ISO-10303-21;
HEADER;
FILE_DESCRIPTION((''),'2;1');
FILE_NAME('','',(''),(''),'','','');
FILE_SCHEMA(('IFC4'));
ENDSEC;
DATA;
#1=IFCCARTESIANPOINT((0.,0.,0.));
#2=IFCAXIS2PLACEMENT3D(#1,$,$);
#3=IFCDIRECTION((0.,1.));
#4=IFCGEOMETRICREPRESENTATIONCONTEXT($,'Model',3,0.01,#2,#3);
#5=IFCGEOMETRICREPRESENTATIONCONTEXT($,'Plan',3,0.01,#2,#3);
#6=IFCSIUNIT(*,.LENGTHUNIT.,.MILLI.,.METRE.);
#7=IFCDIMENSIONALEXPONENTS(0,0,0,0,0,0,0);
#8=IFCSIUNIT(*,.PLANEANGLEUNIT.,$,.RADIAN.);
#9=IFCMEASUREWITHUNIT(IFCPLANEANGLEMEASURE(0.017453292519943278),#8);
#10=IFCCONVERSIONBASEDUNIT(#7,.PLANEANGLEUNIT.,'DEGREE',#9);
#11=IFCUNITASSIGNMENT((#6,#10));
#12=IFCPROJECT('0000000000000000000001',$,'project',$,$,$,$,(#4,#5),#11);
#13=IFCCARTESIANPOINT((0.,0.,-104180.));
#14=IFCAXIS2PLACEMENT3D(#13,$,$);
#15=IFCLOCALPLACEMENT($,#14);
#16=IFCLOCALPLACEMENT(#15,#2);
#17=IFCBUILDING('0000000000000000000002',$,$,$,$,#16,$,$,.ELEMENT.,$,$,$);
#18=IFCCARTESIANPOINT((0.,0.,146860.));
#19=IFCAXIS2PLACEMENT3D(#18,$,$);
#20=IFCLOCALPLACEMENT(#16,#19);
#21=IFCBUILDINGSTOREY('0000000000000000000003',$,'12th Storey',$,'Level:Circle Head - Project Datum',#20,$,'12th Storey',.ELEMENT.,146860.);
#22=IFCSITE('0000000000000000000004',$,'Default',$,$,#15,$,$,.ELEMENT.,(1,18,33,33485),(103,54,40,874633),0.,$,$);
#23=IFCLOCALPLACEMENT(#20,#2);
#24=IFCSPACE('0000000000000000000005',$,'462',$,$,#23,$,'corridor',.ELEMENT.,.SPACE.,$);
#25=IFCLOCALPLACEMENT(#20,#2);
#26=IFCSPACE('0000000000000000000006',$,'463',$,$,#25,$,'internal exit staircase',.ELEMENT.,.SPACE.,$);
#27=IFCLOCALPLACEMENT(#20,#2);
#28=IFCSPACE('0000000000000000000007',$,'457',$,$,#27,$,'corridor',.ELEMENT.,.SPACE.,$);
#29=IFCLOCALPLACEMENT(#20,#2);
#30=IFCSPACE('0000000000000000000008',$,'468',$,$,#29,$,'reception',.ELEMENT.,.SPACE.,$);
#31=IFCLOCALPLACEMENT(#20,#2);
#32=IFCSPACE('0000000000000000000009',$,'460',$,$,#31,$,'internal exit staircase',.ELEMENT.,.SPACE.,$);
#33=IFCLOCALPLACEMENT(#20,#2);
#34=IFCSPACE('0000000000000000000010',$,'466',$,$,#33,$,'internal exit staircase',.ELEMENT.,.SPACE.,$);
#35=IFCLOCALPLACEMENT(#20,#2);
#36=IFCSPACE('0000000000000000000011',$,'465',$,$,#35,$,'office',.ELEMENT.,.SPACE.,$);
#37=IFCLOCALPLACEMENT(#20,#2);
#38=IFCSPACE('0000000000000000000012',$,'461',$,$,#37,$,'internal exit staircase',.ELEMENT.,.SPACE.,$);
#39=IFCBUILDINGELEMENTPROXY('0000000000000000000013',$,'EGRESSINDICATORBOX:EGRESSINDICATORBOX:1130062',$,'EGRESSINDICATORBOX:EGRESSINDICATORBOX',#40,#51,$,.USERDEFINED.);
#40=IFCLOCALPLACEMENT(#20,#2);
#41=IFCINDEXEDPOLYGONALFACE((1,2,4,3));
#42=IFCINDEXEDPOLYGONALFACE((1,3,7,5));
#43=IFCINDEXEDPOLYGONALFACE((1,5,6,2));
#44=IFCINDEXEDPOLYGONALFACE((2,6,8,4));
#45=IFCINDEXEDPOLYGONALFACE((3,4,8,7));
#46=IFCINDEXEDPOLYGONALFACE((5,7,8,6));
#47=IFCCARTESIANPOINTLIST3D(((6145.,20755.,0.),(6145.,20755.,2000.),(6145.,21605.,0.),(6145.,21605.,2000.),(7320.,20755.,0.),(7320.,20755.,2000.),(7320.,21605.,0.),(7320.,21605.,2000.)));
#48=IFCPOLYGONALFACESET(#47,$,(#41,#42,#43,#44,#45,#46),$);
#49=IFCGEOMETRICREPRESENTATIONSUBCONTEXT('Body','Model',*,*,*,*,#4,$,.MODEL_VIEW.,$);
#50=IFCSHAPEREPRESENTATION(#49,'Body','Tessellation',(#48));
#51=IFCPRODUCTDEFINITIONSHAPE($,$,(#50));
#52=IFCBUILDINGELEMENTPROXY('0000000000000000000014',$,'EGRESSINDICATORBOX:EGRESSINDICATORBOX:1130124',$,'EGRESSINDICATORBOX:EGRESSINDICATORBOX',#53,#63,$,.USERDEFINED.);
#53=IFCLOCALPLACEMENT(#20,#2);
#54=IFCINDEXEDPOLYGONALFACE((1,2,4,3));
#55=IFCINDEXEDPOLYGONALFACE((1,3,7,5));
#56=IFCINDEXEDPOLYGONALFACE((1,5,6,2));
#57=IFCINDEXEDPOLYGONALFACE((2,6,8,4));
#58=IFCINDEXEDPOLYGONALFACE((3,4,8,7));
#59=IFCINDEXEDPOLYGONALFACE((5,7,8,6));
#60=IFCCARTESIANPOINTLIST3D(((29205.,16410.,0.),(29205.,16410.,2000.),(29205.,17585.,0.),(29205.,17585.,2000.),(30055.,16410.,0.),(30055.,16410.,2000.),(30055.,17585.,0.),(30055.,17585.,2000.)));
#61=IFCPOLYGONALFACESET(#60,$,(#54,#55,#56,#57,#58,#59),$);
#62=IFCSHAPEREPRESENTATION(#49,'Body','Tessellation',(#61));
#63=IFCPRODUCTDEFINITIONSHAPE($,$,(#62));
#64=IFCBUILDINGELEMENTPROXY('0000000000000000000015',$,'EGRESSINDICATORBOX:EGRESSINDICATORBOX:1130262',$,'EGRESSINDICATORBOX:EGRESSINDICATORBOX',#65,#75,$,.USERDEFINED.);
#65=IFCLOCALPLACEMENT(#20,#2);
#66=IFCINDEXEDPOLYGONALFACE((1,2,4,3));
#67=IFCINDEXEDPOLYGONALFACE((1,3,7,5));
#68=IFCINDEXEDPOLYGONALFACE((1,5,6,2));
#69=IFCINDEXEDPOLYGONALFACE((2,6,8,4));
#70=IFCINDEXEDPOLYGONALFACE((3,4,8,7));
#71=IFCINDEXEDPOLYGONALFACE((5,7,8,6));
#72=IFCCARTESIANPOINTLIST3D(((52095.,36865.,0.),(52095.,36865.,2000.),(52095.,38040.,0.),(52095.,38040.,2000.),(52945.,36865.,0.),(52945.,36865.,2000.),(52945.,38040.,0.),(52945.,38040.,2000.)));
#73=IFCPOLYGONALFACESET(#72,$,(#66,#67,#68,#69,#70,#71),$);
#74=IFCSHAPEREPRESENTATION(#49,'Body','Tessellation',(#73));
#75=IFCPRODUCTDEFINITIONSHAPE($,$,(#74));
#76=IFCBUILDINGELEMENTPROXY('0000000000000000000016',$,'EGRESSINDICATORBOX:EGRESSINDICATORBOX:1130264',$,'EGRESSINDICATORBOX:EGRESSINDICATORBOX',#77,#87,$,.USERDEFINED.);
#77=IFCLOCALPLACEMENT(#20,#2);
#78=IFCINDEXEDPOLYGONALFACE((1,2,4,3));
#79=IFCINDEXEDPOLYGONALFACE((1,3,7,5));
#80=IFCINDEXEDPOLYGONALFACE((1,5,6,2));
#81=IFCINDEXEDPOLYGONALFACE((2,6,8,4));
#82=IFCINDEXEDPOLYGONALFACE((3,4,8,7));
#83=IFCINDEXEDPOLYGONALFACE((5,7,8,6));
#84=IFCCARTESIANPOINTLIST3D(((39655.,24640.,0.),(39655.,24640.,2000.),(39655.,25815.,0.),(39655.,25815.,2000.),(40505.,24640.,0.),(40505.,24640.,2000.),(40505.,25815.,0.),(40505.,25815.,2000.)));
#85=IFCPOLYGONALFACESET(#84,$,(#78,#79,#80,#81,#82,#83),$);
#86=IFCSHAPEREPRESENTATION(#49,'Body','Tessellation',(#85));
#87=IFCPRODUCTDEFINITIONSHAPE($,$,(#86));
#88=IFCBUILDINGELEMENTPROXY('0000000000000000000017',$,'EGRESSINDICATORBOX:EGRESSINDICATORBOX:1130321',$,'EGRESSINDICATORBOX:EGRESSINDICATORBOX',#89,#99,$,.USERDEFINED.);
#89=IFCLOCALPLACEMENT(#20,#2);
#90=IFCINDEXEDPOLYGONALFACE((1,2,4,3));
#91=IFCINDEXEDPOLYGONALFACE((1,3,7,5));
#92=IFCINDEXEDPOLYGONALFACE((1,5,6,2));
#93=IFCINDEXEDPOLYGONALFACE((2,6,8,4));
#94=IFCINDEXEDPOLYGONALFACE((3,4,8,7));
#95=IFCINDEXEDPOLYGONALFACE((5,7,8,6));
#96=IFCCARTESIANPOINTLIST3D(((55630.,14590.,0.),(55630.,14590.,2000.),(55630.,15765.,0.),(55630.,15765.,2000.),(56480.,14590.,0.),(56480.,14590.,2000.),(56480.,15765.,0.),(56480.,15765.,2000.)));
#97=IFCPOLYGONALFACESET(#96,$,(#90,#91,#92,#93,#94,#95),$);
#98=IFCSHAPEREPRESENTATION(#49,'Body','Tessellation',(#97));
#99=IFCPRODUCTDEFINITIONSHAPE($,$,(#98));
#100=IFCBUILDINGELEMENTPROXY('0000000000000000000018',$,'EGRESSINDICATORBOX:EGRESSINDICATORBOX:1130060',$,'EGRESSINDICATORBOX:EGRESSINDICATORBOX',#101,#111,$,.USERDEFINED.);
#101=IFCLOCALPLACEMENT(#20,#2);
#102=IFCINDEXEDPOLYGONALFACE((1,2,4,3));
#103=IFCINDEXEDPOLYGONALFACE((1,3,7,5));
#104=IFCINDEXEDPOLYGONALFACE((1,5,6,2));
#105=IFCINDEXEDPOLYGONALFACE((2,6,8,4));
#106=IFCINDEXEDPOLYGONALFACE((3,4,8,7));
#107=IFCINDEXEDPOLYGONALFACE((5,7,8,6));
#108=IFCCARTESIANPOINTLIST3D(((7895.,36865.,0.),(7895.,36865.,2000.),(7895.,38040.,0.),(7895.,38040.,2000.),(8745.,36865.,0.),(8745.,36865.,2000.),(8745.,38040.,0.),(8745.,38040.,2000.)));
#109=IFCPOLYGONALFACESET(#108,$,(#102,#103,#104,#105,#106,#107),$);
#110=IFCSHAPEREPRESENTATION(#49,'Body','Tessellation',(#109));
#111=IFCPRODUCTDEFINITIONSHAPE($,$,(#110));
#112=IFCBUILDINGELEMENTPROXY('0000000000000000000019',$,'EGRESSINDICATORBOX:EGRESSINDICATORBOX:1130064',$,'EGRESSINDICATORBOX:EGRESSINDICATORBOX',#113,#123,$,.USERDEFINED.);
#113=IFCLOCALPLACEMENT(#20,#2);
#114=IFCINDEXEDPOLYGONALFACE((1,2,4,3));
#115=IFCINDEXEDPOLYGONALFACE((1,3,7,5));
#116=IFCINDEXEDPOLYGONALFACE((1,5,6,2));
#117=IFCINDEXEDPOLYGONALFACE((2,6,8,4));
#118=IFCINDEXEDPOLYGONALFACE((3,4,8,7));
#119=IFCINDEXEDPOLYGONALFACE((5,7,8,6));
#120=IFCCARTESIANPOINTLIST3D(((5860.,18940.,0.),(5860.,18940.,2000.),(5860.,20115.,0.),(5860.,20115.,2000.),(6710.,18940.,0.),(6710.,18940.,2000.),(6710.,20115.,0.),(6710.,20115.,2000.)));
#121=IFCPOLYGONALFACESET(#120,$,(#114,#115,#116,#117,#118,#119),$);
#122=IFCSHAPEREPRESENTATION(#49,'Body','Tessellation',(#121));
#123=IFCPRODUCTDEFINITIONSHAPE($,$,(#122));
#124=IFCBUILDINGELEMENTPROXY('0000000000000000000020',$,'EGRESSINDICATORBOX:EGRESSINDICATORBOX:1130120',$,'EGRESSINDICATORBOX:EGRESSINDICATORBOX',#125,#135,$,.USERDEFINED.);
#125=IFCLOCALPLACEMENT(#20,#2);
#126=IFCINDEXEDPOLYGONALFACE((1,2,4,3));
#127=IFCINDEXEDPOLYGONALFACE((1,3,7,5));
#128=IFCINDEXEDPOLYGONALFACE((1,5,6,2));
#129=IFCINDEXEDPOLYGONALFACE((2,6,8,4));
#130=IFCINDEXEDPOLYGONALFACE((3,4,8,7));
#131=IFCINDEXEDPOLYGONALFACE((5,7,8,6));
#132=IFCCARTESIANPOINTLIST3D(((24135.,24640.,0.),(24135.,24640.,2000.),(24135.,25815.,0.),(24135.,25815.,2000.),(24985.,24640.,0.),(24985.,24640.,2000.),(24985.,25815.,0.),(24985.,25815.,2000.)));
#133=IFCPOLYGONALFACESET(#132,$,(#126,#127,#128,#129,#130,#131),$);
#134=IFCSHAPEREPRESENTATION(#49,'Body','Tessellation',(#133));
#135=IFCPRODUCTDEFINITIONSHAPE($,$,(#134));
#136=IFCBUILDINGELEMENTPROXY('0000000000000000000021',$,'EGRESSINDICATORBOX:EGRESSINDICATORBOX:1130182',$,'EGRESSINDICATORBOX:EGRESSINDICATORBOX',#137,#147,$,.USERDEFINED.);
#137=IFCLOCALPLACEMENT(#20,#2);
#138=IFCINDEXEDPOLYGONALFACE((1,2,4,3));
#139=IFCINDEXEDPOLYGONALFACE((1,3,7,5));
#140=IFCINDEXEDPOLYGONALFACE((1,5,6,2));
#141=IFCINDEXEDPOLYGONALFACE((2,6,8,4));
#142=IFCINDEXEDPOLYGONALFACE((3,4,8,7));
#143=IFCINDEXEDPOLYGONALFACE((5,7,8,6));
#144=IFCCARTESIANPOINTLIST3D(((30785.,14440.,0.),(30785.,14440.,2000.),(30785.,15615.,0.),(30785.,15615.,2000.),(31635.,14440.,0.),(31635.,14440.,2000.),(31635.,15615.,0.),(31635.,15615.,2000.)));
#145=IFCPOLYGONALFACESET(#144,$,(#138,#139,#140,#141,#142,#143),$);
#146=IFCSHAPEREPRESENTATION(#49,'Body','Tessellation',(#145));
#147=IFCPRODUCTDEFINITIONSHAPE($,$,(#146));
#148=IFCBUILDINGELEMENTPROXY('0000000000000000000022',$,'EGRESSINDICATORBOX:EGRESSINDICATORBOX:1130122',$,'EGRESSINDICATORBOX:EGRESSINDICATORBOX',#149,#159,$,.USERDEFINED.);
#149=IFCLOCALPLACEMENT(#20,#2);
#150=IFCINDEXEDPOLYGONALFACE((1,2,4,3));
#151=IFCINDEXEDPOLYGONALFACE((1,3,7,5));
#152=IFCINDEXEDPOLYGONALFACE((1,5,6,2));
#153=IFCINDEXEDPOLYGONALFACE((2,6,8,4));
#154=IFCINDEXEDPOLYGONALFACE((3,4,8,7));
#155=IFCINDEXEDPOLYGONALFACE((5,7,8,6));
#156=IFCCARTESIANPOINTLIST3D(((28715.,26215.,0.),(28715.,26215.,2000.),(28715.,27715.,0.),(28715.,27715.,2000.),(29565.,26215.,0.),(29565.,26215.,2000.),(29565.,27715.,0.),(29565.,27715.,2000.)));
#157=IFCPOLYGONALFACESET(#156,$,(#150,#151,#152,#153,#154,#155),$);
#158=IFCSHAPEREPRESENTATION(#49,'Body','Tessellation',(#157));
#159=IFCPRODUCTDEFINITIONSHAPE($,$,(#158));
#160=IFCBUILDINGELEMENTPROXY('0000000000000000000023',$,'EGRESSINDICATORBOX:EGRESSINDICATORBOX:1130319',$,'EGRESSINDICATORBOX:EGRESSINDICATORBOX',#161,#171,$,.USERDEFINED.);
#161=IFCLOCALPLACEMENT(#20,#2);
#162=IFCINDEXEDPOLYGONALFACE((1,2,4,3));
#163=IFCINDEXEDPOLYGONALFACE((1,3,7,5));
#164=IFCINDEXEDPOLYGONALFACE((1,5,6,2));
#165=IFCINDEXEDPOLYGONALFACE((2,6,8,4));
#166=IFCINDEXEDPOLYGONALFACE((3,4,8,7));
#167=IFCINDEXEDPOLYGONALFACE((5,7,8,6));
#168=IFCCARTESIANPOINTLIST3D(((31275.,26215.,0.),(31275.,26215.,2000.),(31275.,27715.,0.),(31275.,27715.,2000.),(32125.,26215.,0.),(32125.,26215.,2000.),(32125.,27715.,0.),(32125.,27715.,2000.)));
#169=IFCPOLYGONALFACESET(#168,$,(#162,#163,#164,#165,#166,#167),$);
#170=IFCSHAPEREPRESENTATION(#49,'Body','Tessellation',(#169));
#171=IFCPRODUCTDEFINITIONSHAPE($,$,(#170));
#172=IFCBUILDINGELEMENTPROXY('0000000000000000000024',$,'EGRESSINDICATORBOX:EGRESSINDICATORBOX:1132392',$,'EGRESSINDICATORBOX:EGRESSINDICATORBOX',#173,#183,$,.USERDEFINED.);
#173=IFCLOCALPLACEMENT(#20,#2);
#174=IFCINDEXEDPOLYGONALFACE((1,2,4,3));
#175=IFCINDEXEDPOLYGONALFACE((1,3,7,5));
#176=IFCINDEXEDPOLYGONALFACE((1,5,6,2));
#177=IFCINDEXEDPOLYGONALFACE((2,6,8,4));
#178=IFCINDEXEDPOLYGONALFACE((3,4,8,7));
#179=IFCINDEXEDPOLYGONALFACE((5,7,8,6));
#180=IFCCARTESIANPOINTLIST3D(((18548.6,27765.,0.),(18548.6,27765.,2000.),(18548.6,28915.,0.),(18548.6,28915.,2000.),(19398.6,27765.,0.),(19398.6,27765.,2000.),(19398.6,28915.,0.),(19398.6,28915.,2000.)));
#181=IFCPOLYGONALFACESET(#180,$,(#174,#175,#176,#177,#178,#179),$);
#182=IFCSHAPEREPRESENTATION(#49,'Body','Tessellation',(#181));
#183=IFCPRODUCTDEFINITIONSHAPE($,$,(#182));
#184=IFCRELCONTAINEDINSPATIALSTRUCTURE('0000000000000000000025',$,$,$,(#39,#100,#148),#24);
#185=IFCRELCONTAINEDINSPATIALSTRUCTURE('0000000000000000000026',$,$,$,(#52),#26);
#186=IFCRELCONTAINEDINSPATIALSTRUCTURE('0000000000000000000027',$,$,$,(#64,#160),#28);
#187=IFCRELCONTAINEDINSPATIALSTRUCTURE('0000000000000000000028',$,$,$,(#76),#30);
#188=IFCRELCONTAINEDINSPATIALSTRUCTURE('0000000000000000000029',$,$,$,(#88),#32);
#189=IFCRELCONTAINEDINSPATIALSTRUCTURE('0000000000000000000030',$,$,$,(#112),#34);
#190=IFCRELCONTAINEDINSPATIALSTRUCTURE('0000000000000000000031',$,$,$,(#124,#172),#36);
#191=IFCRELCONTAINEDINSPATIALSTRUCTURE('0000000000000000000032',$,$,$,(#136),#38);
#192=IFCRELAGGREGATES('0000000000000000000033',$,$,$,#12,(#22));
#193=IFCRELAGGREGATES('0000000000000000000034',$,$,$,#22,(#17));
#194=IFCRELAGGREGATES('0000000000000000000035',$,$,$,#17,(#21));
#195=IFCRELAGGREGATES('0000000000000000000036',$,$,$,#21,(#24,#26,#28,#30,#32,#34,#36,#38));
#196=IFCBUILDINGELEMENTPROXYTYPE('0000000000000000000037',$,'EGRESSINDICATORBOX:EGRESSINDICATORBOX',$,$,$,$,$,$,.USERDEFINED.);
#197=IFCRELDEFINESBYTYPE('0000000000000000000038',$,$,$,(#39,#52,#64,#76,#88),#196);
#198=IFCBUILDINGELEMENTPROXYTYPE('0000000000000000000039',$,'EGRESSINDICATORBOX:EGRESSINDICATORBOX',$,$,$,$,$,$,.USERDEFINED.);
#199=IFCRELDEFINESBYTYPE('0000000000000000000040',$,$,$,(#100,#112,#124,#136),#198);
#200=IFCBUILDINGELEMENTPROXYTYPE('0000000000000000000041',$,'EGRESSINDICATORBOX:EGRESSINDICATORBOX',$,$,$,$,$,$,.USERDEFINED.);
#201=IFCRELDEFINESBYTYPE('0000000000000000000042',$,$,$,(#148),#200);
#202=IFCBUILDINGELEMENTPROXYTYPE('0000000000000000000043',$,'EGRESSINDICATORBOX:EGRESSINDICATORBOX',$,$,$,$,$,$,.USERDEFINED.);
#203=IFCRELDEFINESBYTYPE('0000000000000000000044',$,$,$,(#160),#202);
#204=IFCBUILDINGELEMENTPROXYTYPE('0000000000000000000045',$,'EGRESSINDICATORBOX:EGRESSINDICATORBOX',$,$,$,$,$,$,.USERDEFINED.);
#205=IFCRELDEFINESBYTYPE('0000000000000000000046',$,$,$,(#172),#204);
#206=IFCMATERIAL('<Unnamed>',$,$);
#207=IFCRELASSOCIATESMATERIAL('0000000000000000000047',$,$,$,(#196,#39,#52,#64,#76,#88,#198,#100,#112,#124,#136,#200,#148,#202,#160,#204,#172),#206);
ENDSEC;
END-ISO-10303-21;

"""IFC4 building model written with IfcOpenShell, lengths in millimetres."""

from ifc_helpers import new_model, entity, si_unit, converted_unit, direction, frame, origin, place, context, subcontext, project, spatial, indexed_curve, outline, extrude, source, transform, mapped, material, type_object, type_shapes, element, save


model = new_model("IFC4")

# Units and contexts
model_context = context("Model", 3, precision=0.01, world=origin(), true_north=direction((0.0, 1.0)))
plan_context = context("Plan", 3, precision=0.01, world=origin(), true_north=direction((0.0, 1.0)))
body_context = subcontext(model_context, "Body", "Model", "MODEL_VIEW")
ifc_project = project(units=[si_unit("LENGTHUNIT", "METRE", prefix="MILLI"), converted_unit("PLANEANGLEUNIT", "DEGREE", entity("IfcPlaneAngleMeasure", 0.017453292519943278), si_unit("PLANEANGLEUNIT", "RADIAN"), dimensions=[0, 0, 0, 0, 0, 0, 0])], contexts=[model_context, plan_context])

# Site, building, storey
site_placement = place(None, frame((0.0, 0.0, -104180.0)))
site = spatial("IfcSite", under=ifc_project, at=site_placement, Name="Default", CompositionType="ELEMENT", RefLatitude=(1, 18, 33, 33485), RefLongitude=(103, 54, 40, 874633), RefElevation=0.0)
building_placement = place(site_placement, origin())
building = spatial("IfcBuilding", under=site, at=building_placement, CompositionType="ELEMENT")
storey_placement = place(building_placement, frame((0.0, 0.0, 146860.0)))
storey = spatial("IfcBuildingStorey", under=building, at=storey_placement, Name="12th Storey", ObjectType="Level:Circle Head - Project Datum", LongName="12th Storey", CompositionType="ELEMENT", Elevation=146860.0)

# Shared definitions
space_1_placement = place(storey_placement, origin())
space_1 = spatial("IfcSpace", under=storey, at=space_1_placement, Name="462", LongName="corridor", CompositionType="ELEMENT", PredefinedType="SPACE")

# Building element proxy
ifc_material_1 = material(Name="<Unnamed>")
building_element_proxy_type_1 = type_object("IfcBuildingElementProxyType", Name="EGRESSINDICATORBOX:EGRESSINDICATORBOX", PredefinedType="USERDEFINED", material=ifc_material_1)
shared_shape_1 = source(origin(), body_context, "Body", "SweptSolid", [
    extrude(outline(indexed_curve([(-587.5, -425.0), (587.5, -425.0), (587.5, 425.0), (-587.5, 425.0), (-587.5, -425.0)], self_intersect=False)), frame((0.0, 0.0, 0.0), z_axis=(0.0, 0.0, 1.0), x_axis=(0.0, 1.0, 0.0)), (0.0, 0.0, 1.0), 2000.0),
])
type_shapes(building_element_proxy_type_1, [shared_shape_1])
proxy_1_placement = place(space_1_placement, frame((6732.5, 21180.0, 0.0), z_axis=(0.0, 0.0, 1.0), x_axis=(0.0, -1.0, 0.0)))
element("IfcBuildingElementProxy", 1, at=proxy_1_placement, inside=space_1, type_object=building_element_proxy_type_1, material=ifc_material_1, Name="EGRESSINDICATORBOX:EGRESSINDICATORBOX:1130062", ObjectType="EGRESSINDICATORBOX:EGRESSINDICATORBOX", PredefinedType="USERDEFINED", context=body_context, shape_type="MappedRepresentation", body=[
    mapped(shared_shape_1, transform((0.0, 0.0, 0.0), scale=1.0)),
])

# Shared definitions
space_2_placement = place(storey_placement, origin())
space_2 = spatial("IfcSpace", under=storey, at=space_2_placement, Name="463", LongName="internal exit staircase", CompositionType="ELEMENT", PredefinedType="SPACE")

# Building element proxy
proxy_2_placement = place(space_2_placement, frame((29630.0, 16997.5, 0.0)))
element("IfcBuildingElementProxy", 2, at=proxy_2_placement, inside=space_2, type_object=building_element_proxy_type_1, material=ifc_material_1, Name="EGRESSINDICATORBOX:EGRESSINDICATORBOX:1130124", ObjectType="EGRESSINDICATORBOX:EGRESSINDICATORBOX", PredefinedType="USERDEFINED", context=body_context, shape_type="MappedRepresentation", body=[
    mapped(shared_shape_1, transform((0.0, 0.0, 0.0), scale=1.0)),
])

# Shared definitions
space_3_placement = place(storey_placement, origin())
space_3 = spatial("IfcSpace", under=storey, at=space_3_placement, Name="457", LongName="corridor", CompositionType="ELEMENT", PredefinedType="SPACE")

# Building element proxy
proxy_3_placement = place(space_3_placement, frame((52520.0, 37452.5, 0.0), z_axis=(0.0, 0.0, 1.0), x_axis=(-1.0, 0.0, 0.0)))
element("IfcBuildingElementProxy", 3, at=proxy_3_placement, inside=space_3, type_object=building_element_proxy_type_1, material=ifc_material_1, Name="EGRESSINDICATORBOX:EGRESSINDICATORBOX:1130262", ObjectType="EGRESSINDICATORBOX:EGRESSINDICATORBOX", PredefinedType="USERDEFINED", context=body_context, shape_type="MappedRepresentation", body=[
    mapped(shared_shape_1, transform((0.0, 0.0, 0.0), scale=1.0)),
])

# Shared definitions
space_4_placement = place(storey_placement, origin())
space_4 = spatial("IfcSpace", under=storey, at=space_4_placement, Name="468", LongName="reception", CompositionType="ELEMENT", PredefinedType="SPACE")

# Building element proxy
proxy_4_placement = place(space_4_placement, frame((40080.0, 25227.5, 0.0), z_axis=(0.0, 0.0, 1.0), x_axis=(-1.0, 0.0, 0.0)))
element("IfcBuildingElementProxy", 4, at=proxy_4_placement, inside=space_4, type_object=building_element_proxy_type_1, material=ifc_material_1, Name="EGRESSINDICATORBOX:EGRESSINDICATORBOX:1130264", ObjectType="EGRESSINDICATORBOX:EGRESSINDICATORBOX", PredefinedType="USERDEFINED", context=body_context, shape_type="MappedRepresentation", body=[
    mapped(shared_shape_1, transform((0.0, 0.0, 0.0), scale=1.0)),
])

# Shared definitions
space_5_placement = place(storey_placement, origin())
space_5 = spatial("IfcSpace", under=storey, at=space_5_placement, Name="460", LongName="internal exit staircase", CompositionType="ELEMENT", PredefinedType="SPACE")

# Building element proxies
proxy_5_placement = place(space_5_placement, frame((56055.0, 15177.5, 0.0)))
element("IfcBuildingElementProxy", 5, at=proxy_5_placement, inside=space_5, type_object=building_element_proxy_type_1, material=ifc_material_1, Name="EGRESSINDICATORBOX:EGRESSINDICATORBOX:1130321", ObjectType="EGRESSINDICATORBOX:EGRESSINDICATORBOX", PredefinedType="USERDEFINED", context=body_context, shape_type="MappedRepresentation", body=[
    mapped(shared_shape_1, transform((0.0, 0.0, 0.0), scale=1.0)),
])
building_element_proxy_type_2 = type_object("IfcBuildingElementProxyType", Name="EGRESSINDICATORBOX:EGRESSINDICATORBOX", PredefinedType="USERDEFINED", material=ifc_material_1)
shared_shape_2 = source(origin(), body_context, "Body", "SweptSolid", [
    extrude(outline(indexed_curve([(-425.0, -587.5), (425.0, -587.5), (425.0, 587.5), (-425.0, 587.5), (-425.0, -587.5)], self_intersect=False)), frame((0.0, 0.0, 0.0), z_axis=(0.0, 0.0, 1.0), x_axis=(-1.0, 0.0, 0.0)), (0.0, 0.0, 1.0), 2000.0),
])
type_shapes(building_element_proxy_type_2, [shared_shape_2])
proxy_6_placement = place(space_1_placement, frame((8320.0, 37452.5, 0.0)))
element("IfcBuildingElementProxy", 6, at=proxy_6_placement, inside=space_1, type_object=building_element_proxy_type_2, material=ifc_material_1, Name="EGRESSINDICATORBOX:EGRESSINDICATORBOX:1130060", ObjectType="EGRESSINDICATORBOX:EGRESSINDICATORBOX", PredefinedType="USERDEFINED", context=body_context, shape_type="MappedRepresentation", body=[
    mapped(shared_shape_2, transform((0.0, 0.0, 0.0), scale=1.0)),
])

# Shared definitions
space_6_placement = place(storey_placement, origin())
space_6 = spatial("IfcSpace", under=storey, at=space_6_placement, Name="466", LongName="internal exit staircase", CompositionType="ELEMENT", PredefinedType="SPACE")

# Building element proxy
proxy_7_placement = place(space_6_placement, frame((6285.0, 19527.5, 0.0), z_axis=(0.0, 0.0, 1.0), x_axis=(-1.0, 0.0, 0.0)))
element("IfcBuildingElementProxy", 7, at=proxy_7_placement, inside=space_6, type_object=building_element_proxy_type_2, material=ifc_material_1, Name="EGRESSINDICATORBOX:EGRESSINDICATORBOX:1130064", ObjectType="EGRESSINDICATORBOX:EGRESSINDICATORBOX", PredefinedType="USERDEFINED", context=body_context, shape_type="MappedRepresentation", body=[
    mapped(shared_shape_2, transform((0.0, 0.0, 0.0), scale=1.0)),
])

# Shared definitions
space_7_placement = place(storey_placement, origin())
space_7 = spatial("IfcSpace", under=storey, at=space_7_placement, Name="465", LongName="office", CompositionType="ELEMENT", PredefinedType="SPACE")

# Building element proxy
proxy_8_placement = place(space_7_placement, frame((24560.0, 25227.5, 0.0)))
element("IfcBuildingElementProxy", 8, at=proxy_8_placement, inside=space_7, type_object=building_element_proxy_type_2, material=ifc_material_1, Name="EGRESSINDICATORBOX:EGRESSINDICATORBOX:1130120", ObjectType="EGRESSINDICATORBOX:EGRESSINDICATORBOX", PredefinedType="USERDEFINED", context=body_context, shape_type="MappedRepresentation", body=[
    mapped(shared_shape_2, transform((0.0, 0.0, 0.0), scale=1.0)),
])

# Shared definitions
space_8_placement = place(storey_placement, origin())
space_8 = spatial("IfcSpace", under=storey, at=space_8_placement, Name="461", LongName="internal exit staircase", CompositionType="ELEMENT", PredefinedType="SPACE")

# Building element proxies
proxy_9_placement = place(space_8_placement, frame((31210.0, 15027.5, 0.0), z_axis=(0.0, 0.0, 1.0), x_axis=(-1.0, 0.0, 0.0)))
element("IfcBuildingElementProxy", 9, at=proxy_9_placement, inside=space_8, type_object=building_element_proxy_type_2, material=ifc_material_1, Name="EGRESSINDICATORBOX:EGRESSINDICATORBOX:1130182", ObjectType="EGRESSINDICATORBOX:EGRESSINDICATORBOX", PredefinedType="USERDEFINED", context=body_context, shape_type="MappedRepresentation", body=[
    mapped(shared_shape_2, transform((0.0, 0.0, 0.0), scale=1.0)),
])
building_element_proxy_type_3 = type_object("IfcBuildingElementProxyType", Name="EGRESSINDICATORBOX:EGRESSINDICATORBOX", PredefinedType="USERDEFINED", material=ifc_material_1)
shared_shape_3 = source(origin(), body_context, "Body", "SweptSolid", [
    extrude(outline(indexed_curve([(-425.0, -750.0), (425.0, -750.0), (425.0, 750.0), (-425.0, 750.0), (-425.0, -750.0)], self_intersect=False)), frame((0.0, 0.0, 0.0), z_axis=(0.0, 0.0, 1.0), x_axis=(-1.0, 0.0, 0.0)), (0.0, 0.0, 1.0), 2000.0),
])
type_shapes(building_element_proxy_type_3, [shared_shape_3])
proxy_10_placement = place(space_1_placement, frame((29140.0, 26965.0, 0.0)))
element("IfcBuildingElementProxy", 10, at=proxy_10_placement, inside=space_1, type_object=building_element_proxy_type_3, material=ifc_material_1, Name="EGRESSINDICATORBOX:EGRESSINDICATORBOX:1130122", ObjectType="EGRESSINDICATORBOX:EGRESSINDICATORBOX", PredefinedType="USERDEFINED", context=body_context, shape_type="MappedRepresentation", body=[
    mapped(shared_shape_3, transform((0.0, 0.0, 0.0), scale=1.0)),
])
building_element_proxy_type_4 = type_object("IfcBuildingElementProxyType", Name="EGRESSINDICATORBOX:EGRESSINDICATORBOX", PredefinedType="USERDEFINED", material=ifc_material_1)
shared_shape_4 = source(origin(), body_context, "Body", "SweptSolid", [
    extrude(outline(indexed_curve([(-750.0, -425.0), (750.0, -425.0), (750.0, 425.0), (-750.0, 425.0), (-750.0, -425.0)], self_intersect=False)), frame((0.0, 0.0, 0.0), z_axis=(0.0, 0.0, 1.0), x_axis=(0.0, 1.0, 0.0)), (0.0, 0.0, 1.0), 2000.0),
])
type_shapes(building_element_proxy_type_4, [shared_shape_4])
proxy_11_placement = place(space_3_placement, frame((31700.0, 26965.0, 0.0), z_axis=(0.0, 0.0, 1.0), x_axis=(-1.0, 0.0, 0.0)))
element("IfcBuildingElementProxy", 11, at=proxy_11_placement, inside=space_3, type_object=building_element_proxy_type_4, material=ifc_material_1, Name="EGRESSINDICATORBOX:EGRESSINDICATORBOX:1130319", ObjectType="EGRESSINDICATORBOX:EGRESSINDICATORBOX", PredefinedType="USERDEFINED", context=body_context, shape_type="MappedRepresentation", body=[
    mapped(shared_shape_4, transform((0.0, 0.0, 0.0), scale=1.0)),
])
building_element_proxy_type_5 = type_object("IfcBuildingElementProxyType", Name="EGRESSINDICATORBOX:EGRESSINDICATORBOX", PredefinedType="USERDEFINED", material=ifc_material_1)
shared_shape_5 = source(origin(), body_context, "Body", "SweptSolid", [
    extrude(outline(indexed_curve([(-575.0, -425.0), (575.0, -425.0), (575.0, 425.0), (-575.0, 425.0), (-575.0, -425.0)], self_intersect=False)), frame((0.0, 0.0, 0.0), z_axis=(0.0, 0.0, 1.0), x_axis=(0.0, 1.0, 0.0)), (0.0, 0.0, 1.0), 2000.0),
])
type_shapes(building_element_proxy_type_5, [shared_shape_5])
proxy_12_placement = place(space_7_placement, frame((18973.6, 28340.0, 0.0), z_axis=(0.0, 0.0, 1.0), x_axis=(-1.0, 0.0, 0.0)))
element("IfcBuildingElementProxy", 12, at=proxy_12_placement, inside=space_7, type_object=building_element_proxy_type_5, material=ifc_material_1, Name="EGRESSINDICATORBOX:EGRESSINDICATORBOX:1132392", ObjectType="EGRESSINDICATORBOX:EGRESSINDICATORBOX", PredefinedType="USERDEFINED", context=body_context, shape_type="MappedRepresentation", body=[
    mapped(shared_shape_5, transform((0.0, 0.0, 0.0), scale=1.0)),
])

save(model, "model.ifc")
